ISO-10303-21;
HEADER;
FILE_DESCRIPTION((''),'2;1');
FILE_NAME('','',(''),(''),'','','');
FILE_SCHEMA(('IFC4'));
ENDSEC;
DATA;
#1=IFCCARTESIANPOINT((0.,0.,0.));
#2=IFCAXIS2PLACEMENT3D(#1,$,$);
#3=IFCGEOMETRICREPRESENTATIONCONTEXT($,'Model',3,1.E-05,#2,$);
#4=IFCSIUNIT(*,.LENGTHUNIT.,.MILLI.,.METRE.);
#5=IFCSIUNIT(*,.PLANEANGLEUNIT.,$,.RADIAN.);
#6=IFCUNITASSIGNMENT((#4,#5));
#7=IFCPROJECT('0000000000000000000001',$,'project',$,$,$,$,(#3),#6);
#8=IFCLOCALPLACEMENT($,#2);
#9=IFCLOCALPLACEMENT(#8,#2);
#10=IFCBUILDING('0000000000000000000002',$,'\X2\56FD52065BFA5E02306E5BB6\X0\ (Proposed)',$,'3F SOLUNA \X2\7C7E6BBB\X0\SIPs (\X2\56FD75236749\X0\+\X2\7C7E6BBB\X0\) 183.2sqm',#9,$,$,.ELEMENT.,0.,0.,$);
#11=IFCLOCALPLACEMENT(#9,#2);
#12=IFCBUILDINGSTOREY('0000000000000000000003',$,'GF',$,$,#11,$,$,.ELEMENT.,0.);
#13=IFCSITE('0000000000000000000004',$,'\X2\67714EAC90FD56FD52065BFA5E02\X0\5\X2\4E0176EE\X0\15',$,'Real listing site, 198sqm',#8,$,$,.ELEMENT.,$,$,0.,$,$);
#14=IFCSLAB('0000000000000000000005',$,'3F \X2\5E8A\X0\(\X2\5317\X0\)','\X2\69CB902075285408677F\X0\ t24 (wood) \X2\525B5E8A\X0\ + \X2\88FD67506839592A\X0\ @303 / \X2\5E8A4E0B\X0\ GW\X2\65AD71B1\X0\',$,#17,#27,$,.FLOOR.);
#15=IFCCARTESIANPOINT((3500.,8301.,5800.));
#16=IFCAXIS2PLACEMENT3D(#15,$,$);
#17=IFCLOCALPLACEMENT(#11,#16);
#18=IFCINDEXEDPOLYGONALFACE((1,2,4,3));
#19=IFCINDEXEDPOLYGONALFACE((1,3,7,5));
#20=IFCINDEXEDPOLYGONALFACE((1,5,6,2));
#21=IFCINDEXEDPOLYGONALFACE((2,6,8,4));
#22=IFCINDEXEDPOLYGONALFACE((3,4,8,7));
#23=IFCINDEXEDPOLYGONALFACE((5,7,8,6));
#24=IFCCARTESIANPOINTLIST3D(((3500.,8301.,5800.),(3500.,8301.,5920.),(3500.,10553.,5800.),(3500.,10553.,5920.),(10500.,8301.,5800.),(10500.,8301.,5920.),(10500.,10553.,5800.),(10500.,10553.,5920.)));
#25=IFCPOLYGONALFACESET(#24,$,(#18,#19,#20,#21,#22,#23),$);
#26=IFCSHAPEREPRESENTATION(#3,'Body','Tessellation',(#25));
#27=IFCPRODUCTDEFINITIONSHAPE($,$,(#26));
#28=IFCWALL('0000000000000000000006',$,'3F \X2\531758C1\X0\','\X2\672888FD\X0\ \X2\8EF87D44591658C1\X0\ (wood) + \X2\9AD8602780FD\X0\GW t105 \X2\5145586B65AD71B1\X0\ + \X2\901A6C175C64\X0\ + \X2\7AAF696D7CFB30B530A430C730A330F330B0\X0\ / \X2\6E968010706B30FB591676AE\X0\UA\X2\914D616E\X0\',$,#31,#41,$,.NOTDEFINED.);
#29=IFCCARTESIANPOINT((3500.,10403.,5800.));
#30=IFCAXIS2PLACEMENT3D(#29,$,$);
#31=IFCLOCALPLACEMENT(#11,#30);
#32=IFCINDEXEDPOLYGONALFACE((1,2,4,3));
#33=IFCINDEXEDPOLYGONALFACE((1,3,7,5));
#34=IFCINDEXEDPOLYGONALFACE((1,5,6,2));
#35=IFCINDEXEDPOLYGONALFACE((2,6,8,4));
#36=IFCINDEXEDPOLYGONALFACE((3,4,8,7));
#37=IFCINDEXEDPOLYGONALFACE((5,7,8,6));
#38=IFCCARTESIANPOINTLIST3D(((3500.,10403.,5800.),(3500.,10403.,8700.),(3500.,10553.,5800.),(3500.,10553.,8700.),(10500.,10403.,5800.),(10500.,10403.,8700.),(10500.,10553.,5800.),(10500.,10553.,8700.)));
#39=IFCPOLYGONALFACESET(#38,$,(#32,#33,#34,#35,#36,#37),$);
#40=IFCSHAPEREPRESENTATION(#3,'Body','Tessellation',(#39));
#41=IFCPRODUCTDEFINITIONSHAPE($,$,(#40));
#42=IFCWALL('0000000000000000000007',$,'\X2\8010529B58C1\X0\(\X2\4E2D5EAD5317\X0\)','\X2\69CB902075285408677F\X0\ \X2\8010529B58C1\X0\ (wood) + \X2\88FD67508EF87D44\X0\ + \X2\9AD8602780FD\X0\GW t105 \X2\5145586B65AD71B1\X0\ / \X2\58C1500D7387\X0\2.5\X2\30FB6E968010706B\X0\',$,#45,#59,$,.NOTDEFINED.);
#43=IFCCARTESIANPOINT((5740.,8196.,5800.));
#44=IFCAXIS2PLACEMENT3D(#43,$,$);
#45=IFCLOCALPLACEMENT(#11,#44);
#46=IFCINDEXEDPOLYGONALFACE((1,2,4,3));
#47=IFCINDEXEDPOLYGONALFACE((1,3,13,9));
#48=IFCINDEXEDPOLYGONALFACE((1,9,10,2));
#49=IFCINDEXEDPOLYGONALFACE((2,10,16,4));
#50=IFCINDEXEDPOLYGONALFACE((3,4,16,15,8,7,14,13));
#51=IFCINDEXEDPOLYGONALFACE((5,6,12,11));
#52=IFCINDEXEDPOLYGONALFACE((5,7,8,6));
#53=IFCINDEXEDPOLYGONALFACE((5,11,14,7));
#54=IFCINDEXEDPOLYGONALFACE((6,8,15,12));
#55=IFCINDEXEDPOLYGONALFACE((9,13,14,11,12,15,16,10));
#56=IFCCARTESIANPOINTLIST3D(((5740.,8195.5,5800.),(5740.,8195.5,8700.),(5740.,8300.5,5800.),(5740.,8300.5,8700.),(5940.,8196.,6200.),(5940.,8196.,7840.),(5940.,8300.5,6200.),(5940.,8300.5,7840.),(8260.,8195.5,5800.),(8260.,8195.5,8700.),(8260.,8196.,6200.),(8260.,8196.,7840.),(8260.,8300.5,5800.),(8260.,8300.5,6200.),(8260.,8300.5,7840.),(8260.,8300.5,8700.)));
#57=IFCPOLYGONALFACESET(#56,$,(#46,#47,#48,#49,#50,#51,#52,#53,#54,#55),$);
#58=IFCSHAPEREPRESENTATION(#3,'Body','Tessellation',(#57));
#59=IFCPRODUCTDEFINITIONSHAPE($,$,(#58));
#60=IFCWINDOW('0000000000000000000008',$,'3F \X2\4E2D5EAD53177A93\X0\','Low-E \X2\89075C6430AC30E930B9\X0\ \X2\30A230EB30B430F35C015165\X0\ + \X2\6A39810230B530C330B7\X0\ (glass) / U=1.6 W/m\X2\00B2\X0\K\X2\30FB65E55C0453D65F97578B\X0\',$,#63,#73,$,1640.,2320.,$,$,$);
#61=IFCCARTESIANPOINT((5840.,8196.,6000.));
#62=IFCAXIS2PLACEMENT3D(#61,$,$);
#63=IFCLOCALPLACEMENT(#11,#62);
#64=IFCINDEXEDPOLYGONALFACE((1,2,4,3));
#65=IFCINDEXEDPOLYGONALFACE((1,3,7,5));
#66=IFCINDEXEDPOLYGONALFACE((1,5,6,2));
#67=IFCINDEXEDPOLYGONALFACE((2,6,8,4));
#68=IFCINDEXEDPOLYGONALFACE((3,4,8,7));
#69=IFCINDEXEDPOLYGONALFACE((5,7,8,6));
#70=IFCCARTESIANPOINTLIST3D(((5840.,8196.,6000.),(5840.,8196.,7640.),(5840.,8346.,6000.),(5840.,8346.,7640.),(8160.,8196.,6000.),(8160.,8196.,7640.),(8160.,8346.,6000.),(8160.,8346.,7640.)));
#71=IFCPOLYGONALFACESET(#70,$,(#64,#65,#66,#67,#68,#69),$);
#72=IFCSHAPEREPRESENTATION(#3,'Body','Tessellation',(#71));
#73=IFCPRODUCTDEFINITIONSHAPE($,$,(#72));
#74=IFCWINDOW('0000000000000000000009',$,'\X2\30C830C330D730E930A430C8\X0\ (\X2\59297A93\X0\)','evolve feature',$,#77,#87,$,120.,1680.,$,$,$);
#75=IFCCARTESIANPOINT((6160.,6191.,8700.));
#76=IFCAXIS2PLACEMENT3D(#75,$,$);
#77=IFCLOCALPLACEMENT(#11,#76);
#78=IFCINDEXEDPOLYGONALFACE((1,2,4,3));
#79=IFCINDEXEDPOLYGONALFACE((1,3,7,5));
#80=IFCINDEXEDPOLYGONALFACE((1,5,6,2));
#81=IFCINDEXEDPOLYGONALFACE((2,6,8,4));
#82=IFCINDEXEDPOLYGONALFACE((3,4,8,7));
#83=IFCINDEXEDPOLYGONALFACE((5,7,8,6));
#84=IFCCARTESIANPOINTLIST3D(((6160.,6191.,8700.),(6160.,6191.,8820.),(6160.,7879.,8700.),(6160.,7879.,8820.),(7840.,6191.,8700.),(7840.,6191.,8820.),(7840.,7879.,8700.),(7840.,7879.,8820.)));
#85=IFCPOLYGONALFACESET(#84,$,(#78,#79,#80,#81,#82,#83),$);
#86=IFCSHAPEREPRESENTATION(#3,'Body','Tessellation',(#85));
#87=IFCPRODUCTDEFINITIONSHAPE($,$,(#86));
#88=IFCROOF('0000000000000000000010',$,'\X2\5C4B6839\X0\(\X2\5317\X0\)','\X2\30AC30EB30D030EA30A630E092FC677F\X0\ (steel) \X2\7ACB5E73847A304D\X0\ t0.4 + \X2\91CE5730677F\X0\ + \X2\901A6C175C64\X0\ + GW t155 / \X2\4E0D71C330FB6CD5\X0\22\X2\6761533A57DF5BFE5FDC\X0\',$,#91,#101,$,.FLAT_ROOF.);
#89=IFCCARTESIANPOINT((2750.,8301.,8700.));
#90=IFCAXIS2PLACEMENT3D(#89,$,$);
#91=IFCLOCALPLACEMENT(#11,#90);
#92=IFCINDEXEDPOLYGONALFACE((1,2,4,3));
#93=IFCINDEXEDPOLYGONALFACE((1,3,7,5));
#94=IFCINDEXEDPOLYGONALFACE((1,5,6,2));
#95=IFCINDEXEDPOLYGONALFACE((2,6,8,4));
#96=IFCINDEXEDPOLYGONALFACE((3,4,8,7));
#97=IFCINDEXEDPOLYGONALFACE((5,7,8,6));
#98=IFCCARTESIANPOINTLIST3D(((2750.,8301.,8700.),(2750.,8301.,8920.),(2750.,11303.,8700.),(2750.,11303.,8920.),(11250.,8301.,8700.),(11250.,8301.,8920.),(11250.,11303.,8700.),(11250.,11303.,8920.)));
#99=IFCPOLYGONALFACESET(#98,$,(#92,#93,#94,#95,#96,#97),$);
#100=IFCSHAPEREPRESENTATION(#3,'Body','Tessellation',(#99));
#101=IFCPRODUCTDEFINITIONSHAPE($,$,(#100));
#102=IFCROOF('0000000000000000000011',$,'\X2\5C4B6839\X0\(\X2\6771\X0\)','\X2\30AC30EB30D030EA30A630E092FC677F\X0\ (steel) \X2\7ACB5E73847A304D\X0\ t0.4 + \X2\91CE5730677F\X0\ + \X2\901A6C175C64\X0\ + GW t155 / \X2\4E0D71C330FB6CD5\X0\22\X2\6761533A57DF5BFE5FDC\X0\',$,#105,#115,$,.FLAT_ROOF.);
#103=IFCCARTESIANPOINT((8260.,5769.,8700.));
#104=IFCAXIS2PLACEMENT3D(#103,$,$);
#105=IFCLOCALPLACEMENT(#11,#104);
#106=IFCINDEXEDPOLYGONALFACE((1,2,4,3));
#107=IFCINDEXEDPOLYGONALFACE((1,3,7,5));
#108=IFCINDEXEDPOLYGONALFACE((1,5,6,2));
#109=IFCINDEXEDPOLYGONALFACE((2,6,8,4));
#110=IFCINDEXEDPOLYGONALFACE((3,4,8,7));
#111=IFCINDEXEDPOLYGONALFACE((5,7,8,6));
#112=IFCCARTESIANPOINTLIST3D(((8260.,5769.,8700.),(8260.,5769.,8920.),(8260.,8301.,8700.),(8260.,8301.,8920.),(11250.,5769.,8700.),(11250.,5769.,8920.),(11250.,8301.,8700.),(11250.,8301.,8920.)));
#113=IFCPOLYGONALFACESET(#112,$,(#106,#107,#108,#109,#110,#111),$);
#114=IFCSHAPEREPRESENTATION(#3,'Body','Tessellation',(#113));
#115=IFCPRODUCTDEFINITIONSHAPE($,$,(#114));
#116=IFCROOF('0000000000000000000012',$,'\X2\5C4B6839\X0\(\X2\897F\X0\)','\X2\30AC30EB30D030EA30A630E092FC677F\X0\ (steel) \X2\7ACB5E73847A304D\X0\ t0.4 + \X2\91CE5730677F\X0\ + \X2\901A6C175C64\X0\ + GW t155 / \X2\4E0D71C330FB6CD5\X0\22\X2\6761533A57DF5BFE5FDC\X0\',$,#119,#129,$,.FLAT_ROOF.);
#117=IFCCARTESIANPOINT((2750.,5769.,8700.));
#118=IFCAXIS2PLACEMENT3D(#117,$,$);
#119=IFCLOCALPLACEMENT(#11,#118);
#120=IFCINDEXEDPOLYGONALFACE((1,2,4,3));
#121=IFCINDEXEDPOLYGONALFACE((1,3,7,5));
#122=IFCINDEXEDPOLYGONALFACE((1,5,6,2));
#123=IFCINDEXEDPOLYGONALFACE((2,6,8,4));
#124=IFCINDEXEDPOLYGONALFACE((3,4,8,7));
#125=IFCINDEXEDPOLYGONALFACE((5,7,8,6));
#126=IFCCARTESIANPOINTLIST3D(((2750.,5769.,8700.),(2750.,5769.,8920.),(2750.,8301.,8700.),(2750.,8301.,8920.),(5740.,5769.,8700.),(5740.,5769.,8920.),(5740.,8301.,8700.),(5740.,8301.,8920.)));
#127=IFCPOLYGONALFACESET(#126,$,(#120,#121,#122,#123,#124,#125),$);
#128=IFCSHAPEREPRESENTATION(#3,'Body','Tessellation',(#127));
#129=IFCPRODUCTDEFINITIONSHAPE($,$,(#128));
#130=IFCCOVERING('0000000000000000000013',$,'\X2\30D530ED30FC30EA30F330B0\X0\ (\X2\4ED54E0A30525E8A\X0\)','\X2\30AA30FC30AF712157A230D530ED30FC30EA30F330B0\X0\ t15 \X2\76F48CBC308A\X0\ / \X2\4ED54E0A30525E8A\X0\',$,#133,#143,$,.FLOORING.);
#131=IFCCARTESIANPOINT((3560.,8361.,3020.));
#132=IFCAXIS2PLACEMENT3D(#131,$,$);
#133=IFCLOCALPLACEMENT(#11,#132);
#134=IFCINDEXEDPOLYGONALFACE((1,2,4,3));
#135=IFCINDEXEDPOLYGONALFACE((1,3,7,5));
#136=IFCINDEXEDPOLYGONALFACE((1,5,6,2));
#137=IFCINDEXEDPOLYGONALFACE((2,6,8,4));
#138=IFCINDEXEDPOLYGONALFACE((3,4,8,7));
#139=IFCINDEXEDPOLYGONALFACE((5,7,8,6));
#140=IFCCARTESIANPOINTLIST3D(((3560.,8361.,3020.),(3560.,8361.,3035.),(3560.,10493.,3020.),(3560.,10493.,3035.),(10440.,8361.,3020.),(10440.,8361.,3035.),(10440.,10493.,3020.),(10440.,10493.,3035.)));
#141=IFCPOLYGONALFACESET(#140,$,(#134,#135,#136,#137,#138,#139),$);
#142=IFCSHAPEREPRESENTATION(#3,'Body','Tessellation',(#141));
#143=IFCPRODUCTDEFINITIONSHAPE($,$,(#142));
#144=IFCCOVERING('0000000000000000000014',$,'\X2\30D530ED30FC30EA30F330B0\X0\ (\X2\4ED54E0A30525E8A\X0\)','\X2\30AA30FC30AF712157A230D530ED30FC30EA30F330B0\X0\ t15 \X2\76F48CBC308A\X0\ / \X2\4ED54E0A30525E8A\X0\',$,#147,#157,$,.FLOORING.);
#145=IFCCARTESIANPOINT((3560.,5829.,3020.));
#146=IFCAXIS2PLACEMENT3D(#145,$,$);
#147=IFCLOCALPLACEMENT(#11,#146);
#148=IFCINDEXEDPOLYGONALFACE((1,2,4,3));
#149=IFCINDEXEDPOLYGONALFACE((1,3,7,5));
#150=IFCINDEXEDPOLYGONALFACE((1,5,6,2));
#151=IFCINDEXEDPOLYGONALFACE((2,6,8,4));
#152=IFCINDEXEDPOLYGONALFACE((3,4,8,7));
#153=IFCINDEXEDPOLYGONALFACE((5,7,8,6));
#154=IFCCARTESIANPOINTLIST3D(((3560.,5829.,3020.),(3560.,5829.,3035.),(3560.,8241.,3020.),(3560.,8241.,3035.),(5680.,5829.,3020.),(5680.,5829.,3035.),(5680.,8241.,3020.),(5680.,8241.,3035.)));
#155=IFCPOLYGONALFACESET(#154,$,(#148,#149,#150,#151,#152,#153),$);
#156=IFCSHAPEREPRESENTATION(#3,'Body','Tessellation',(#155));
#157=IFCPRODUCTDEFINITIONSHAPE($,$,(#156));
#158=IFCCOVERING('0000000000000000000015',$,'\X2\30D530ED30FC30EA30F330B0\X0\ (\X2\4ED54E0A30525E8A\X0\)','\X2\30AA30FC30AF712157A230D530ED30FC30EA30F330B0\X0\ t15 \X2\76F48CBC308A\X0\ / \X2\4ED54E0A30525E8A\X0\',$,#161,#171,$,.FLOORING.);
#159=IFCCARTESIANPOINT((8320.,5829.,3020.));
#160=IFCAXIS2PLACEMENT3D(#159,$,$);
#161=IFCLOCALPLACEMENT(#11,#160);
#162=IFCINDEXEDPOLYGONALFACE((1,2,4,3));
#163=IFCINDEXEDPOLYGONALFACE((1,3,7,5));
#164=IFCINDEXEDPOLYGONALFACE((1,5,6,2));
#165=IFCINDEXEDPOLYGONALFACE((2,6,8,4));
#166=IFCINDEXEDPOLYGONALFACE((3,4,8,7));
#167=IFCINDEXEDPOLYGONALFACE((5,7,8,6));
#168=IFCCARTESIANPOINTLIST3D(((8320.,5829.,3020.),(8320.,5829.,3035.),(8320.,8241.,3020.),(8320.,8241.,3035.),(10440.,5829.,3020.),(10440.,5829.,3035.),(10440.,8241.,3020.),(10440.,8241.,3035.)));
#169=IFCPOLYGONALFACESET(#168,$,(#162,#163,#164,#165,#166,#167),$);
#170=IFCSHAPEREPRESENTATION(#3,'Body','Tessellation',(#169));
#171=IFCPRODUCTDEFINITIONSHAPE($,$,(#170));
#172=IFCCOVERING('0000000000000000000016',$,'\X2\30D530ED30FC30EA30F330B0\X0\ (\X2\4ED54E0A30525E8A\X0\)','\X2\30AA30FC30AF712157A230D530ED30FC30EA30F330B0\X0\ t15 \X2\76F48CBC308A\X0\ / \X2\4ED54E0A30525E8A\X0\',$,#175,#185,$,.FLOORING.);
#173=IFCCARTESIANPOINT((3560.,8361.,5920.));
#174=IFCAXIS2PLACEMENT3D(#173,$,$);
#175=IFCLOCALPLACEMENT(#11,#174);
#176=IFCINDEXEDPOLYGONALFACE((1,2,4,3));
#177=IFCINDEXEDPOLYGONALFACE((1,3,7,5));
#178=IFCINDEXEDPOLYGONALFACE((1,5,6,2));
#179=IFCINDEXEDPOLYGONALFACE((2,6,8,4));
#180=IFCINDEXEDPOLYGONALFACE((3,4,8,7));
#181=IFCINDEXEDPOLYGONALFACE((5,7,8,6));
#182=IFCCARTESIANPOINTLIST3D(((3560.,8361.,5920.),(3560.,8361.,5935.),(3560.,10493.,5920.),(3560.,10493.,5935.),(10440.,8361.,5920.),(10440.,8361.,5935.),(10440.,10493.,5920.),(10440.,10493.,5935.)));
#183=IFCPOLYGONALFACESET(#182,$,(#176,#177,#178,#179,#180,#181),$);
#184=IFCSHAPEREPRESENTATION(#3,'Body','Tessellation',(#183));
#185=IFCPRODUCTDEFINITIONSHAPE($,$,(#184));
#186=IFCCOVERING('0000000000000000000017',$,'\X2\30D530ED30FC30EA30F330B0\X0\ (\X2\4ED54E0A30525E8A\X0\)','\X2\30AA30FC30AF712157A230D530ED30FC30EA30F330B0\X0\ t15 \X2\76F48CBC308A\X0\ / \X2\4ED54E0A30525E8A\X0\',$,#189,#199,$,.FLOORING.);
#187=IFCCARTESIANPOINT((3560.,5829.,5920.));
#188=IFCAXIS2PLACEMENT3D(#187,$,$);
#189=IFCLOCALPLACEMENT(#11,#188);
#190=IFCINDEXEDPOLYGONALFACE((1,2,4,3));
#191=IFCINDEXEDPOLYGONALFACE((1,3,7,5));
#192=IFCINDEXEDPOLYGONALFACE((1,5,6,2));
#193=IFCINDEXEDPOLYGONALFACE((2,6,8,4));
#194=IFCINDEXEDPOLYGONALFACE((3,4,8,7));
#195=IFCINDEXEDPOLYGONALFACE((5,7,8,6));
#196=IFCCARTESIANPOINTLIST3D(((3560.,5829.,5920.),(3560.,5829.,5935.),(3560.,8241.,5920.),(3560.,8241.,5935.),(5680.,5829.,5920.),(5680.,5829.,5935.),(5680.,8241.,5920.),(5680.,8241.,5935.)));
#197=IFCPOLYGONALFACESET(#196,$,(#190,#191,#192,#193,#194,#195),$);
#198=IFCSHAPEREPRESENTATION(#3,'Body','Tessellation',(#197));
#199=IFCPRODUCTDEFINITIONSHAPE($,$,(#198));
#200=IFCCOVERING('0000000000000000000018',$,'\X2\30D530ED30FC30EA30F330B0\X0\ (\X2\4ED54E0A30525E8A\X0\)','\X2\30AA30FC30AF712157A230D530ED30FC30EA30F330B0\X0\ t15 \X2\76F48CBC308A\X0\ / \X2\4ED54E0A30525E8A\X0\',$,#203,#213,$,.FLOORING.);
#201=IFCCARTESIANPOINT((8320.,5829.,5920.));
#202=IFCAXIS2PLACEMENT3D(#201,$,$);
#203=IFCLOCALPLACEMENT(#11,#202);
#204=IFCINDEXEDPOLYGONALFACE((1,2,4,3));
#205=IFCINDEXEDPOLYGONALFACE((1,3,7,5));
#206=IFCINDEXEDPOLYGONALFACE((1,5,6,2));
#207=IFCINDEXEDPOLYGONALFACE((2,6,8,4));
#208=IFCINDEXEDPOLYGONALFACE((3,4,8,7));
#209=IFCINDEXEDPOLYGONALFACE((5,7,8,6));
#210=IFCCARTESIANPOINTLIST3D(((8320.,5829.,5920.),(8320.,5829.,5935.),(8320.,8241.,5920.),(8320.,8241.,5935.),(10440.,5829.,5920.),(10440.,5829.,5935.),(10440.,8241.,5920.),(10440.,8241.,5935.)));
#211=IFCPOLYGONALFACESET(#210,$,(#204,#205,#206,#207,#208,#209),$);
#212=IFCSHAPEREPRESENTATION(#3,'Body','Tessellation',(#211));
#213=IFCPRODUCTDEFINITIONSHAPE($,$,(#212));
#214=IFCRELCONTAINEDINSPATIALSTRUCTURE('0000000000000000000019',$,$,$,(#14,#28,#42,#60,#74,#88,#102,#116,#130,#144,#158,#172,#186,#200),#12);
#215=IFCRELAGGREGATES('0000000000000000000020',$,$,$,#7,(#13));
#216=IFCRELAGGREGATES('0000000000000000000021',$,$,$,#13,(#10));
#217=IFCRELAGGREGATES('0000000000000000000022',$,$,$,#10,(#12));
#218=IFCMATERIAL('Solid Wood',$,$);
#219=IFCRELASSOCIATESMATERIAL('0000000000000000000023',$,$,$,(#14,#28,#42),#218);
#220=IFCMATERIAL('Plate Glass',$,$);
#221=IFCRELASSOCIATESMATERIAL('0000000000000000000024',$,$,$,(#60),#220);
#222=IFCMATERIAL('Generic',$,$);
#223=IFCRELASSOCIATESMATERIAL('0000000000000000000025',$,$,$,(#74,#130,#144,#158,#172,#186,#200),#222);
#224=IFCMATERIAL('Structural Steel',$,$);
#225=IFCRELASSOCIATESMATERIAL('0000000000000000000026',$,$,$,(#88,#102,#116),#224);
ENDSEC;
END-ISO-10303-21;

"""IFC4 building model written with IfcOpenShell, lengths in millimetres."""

from ifc_helpers import new_model, si_unit, frame, frame_2d, origin, place, context, project, spatial, rectangle, extrude, material, element, fill, save


model = new_model("IFC4")

# Units and contexts
model_context = context("Model", 3, precision=1e-05, world=origin())
ifc_project = project(units=[si_unit("LENGTHUNIT", "METRE", prefix="MILLI"), si_unit("PLANEANGLEUNIT", "RADIAN")], contexts=[model_context])

# Site, building, storey
site_placement = place(None, origin())
site = spatial("IfcSite", under=ifc_project, at=site_placement, Name="東京都国分寺市5丁目15", ObjectType="Real listing site, 198sqm", CompositionType="ELEMENT", RefElevation=0.0)
building_placement = place(site_placement, origin())
building = spatial("IfcBuilding", under=site, at=building_placement, Name="国分寺市の家 (Proposed)", ObjectType="3F SOLUNA 籾殻SIPs (国産杉+籾殻) 183.2sqm", CompositionType="ELEMENT", ElevationOfRefHeight=0.0, ElevationOfTerrain=0.0)
storey_placement = place(building_placement, origin())
storey = spatial("IfcBuildingStorey", under=building, at=storey_placement, Name="GF", CompositionType="ELEMENT", Elevation=0.0)

# Slab
ifc_material_1 = material(Name="Solid Wood")
slab_placement = place(storey_placement, frame((3500.0, 8301.0, 5800.0)))
element("IfcSlab", 1, at=slab_placement, inside=storey, material=ifc_material_1, Name="3F 床(北)", Description="構造用合板 t24 (wood) 剛床 + 製材根太 @303 / 床下 GW断熱", PredefinedType="FLOOR", context=model_context, shape_type="SweptSolid", body=[
    extrude(rectangle(XDim=7000.0, YDim=2252.0, at=frame_2d((3500.0, 1126.0))), frame((3500.0, 8301.0, 5800.0)), (0.0, 0.0, 1.0), 120.0),
])

# Wall
wall_1_placement = place(storey_placement, frame((3500.0, 10403.0, 5800.0)))
element("IfcWall", 2, at=wall_1_placement, inside=storey, material=ifc_material_1, Name="3F 北壁", Description="木製 軸組外壁 (wood) + 高性能GW t105 充填断熱 + 通気層 + 窯業系サイディング / 準耐火・外皮UA配慮", PredefinedType="NOTDEFINED", context=model_context, shape_type="SweptSolid", body=[
    extrude(rectangle(XDim=7000.0, YDim=150.0, at=frame_2d((3500.0, 75.0))), frame((3500.0, 10403.0, 5800.0)), (0.0, 0.0, 1.0), 2900.0),
])

# Wall, opening, window
wall_2_placement = place(storey_placement, frame((5740.0, 8196.0, 5800.0)))
wall_2 = element("IfcWall", 3, at=wall_2_placement, inside=storey, material=ifc_material_1, Name="耐力壁(中庭北)", Description="構造用合板 耐力壁 (wood) + 製材軸組 + 高性能GW t105 充填断熱 / 壁倍率2.5・準耐火", PredefinedType="NOTDEFINED", context=model_context, shape_type="SweptSolid", body=[
    extrude(rectangle(XDim=2520.0, YDim=105.0, at=frame_2d((1260.0, 52.0))), frame((5740.0, 8196.0, 5800.0)), (0.0, 0.0, 1.0), 2900.0),
])
opening_placement = place(storey_placement, frame((5840.0, 8196.0, 6000.0)))
opening = element("IfcOpeningElement", 4, at=opening_placement, cuts=wall_2, PredefinedType="NOTDEFINED", context=model_context, shape_type="SweptSolid", body=[
    extrude(rectangle(XDim=2320.0, YDim=150.0, at=frame_2d((1160.0, 75.0))), frame((5840.0, 8196.0, 6000.0)), (0.0, 0.0, 1.0), 1640.0),
])
ifc_material_2 = material(Name="Plate Glass")
window_1_placement = place(storey_placement, frame((5840.0, 8196.0, 6000.0)))
window_1 = element("IfcWindow", 5, at=window_1_placement, inside=storey, material=ifc_material_2, Name="3F 中庭北窓", Description="Low-E 複層ガラス アルゴン封入 + 樹脂サッシ (glass) / U=1.6 W/m²K・日射取得型", OverallHeight=1640.0, OverallWidth=2320.0, context=model_context, shape_type="SweptSolid", body=[
    extrude(rectangle(XDim=2320.0, YDim=150.0, at=frame_2d((1160.0, 75.0))), frame((5840.0, 8196.0, 6000.0)), (0.0, 0.0, 1.0), 1640.0),
])
fill(opening, window_1)

# Window
ifc_material_3 = material(Name="Generic")
window_2_placement = place(storey_placement, frame((6160.0, 6191.0, 8700.0)))
element("IfcWindow", 6, at=window_2_placement, inside=storey, material=ifc_material_3, Name="トップライト (天窓)", Description="evolve feature", OverallHeight=120.0, OverallWidth=1680.0, context=model_context, shape_type="SweptSolid", body=[
    extrude(rectangle(XDim=1680.0, YDim=1688.0, at=frame_2d((840.0, 844.0))), frame((6160.0, 6191.0, 8700.0)), (0.0, 0.0, 1.0), 120.0),
])

# Roofs
ifc_material_4 = material(Name="Structural Steel")
roof_1_placement = place(storey_placement, frame((2750.0, 8301.0, 8700.0)))
element("IfcRoof", 7, at=roof_1_placement, inside=storey, material=ifc_material_4, Name="屋根(北)", Description="ガルバリウム鋼板 (steel) 立平葺き t0.4 + 野地板 + 通気層 + GW t155 / 不燃・法22条区域対応", PredefinedType="FLAT_ROOF", context=model_context, shape_type="SweptSolid", body=[
    extrude(rectangle(XDim=8500.0, YDim=3002.0, at=frame_2d((4250.0, 1501.0))), frame((2750.0, 8301.0, 8700.0)), (0.0, 0.0, 1.0), 220.0),
])
roof_2_placement = place(storey_placement, frame((8260.0, 5769.0, 8700.0)))
element("IfcRoof", 8, at=roof_2_placement, inside=storey, material=ifc_material_4, Name="屋根(東)", Description="ガルバリウム鋼板 (steel) 立平葺き t0.4 + 野地板 + 通気層 + GW t155 / 不燃・法22条区域対応", PredefinedType="FLAT_ROOF", context=model_context, shape_type="SweptSolid", body=[
    extrude(rectangle(XDim=2990.0, YDim=2532.0, at=frame_2d((1495.0, 1266.0))), frame((8260.0, 5769.0, 8700.0)), (0.0, 0.0, 1.0), 220.0),
])
roof_3_placement = place(storey_placement, frame((2750.0, 5769.0, 8700.0)))
element("IfcRoof", 9, at=roof_3_placement, inside=storey, material=ifc_material_4, Name="屋根(西)", Description="ガルバリウム鋼板 (steel) 立平葺き t0.4 + 野地板 + 通気層 + GW t155 / 不燃・法22条区域対応", PredefinedType="FLAT_ROOF", context=model_context, shape_type="SweptSolid", body=[
    extrude(rectangle(XDim=2990.0, YDim=2532.0, at=frame_2d((1495.0, 1266.0))), frame((2750.0, 5769.0, 8700.0)), (0.0, 0.0, 1.0), 220.0),
])

# Coverings
covering_1_placement = place(storey_placement, frame((3560.0, 8361.0, 3020.0)))
element("IfcCovering", 10, at=covering_1_placement, inside=storey, material=ifc_material_3, Name="フローリング (仕上げ床)", Description="オーク無垢フローリング t15 直貼り / 仕上げ床", PredefinedType="FLOORING", context=model_context, shape_type="SweptSolid", body=[
    extrude(rectangle(XDim=6880.0, YDim=2132.0, at=frame_2d((3440.0, 1066.0))), frame((3560.0, 8361.0, 3020.0)), (0.0, 0.0, 1.0), 15.0),
])
covering_2_placement = place(storey_placement, frame((3560.0, 5829.0, 3020.0)))
element("IfcCovering", 11, at=covering_2_placement, inside=storey, material=ifc_material_3, Name="フローリング (仕上げ床)", Description="オーク無垢フローリング t15 直貼り / 仕上げ床", PredefinedType="FLOORING", context=model_context, shape_type="SweptSolid", body=[
    extrude(rectangle(XDim=2120.0, YDim=2412.0, at=frame_2d((1060.0, 1206.0))), frame((3560.0, 5829.0, 3020.0)), (0.0, 0.0, 1.0), 15.0),
])
covering_3_placement = place(storey_placement, frame((8320.0, 5829.0, 3020.0)))
element("IfcCovering", 12, at=covering_3_placement, inside=storey, material=ifc_material_3, Name="フローリング (仕上げ床)", Description="オーク無垢フローリング t15 直貼り / 仕上げ床", PredefinedType="FLOORING", context=model_context, shape_type="SweptSolid", body=[
    extrude(rectangle(XDim=2120.0, YDim=2412.0, at=frame_2d((1060.0, 1206.0))), frame((8320.0, 5829.0, 3020.0)), (0.0, 0.0, 1.0), 15.0),
])
covering_4_placement = place(storey_placement, frame((3560.0, 8361.0, 5920.0)))
element("IfcCovering", 13, at=covering_4_placement, inside=storey, material=ifc_material_3, Name="フローリング (仕上げ床)", Description="オーク無垢フローリング t15 直貼り / 仕上げ床", PredefinedType="FLOORING", context=model_context, shape_type="SweptSolid", body=[
    extrude(rectangle(XDim=6880.0, YDim=2132.0, at=frame_2d((3440.0, 1066.0))), frame((3560.0, 8361.0, 5920.0)), (0.0, 0.0, 1.0), 15.0),
])
covering_5_placement = place(storey_placement, frame((3560.0, 5829.0, 5920.0)))
element("IfcCovering", 14, at=covering_5_placement, inside=storey, material=ifc_material_3, Name="フローリング (仕上げ床)", Description="オーク無垢フローリング t15 直貼り / 仕上げ床", PredefinedType="FLOORING", context=model_context, shape_type="SweptSolid", body=[
    extrude(rectangle(XDim=2120.0, YDim=2412.0, at=frame_2d((1060.0, 1206.0))), frame((3560.0, 5829.0, 5920.0)), (0.0, 0.0, 1.0), 15.0),
])
covering_6_placement = place(storey_placement, frame((8320.0, 5829.0, 5920.0)))
element("IfcCovering", 15, at=covering_6_placement, inside=storey, material=ifc_material_3, Name="フローリング (仕上げ床)", Description="オーク無垢フローリング t15 直貼り / 仕上げ床", PredefinedType="FLOORING", context=model_context, shape_type="SweptSolid", body=[
    extrude(rectangle(XDim=2120.0, YDim=2412.0, at=frame_2d((1060.0, 1206.0))), frame((8320.0, 5829.0, 5920.0)), (0.0, 0.0, 1.0), 15.0),
])

save(model, "model.ifc")
